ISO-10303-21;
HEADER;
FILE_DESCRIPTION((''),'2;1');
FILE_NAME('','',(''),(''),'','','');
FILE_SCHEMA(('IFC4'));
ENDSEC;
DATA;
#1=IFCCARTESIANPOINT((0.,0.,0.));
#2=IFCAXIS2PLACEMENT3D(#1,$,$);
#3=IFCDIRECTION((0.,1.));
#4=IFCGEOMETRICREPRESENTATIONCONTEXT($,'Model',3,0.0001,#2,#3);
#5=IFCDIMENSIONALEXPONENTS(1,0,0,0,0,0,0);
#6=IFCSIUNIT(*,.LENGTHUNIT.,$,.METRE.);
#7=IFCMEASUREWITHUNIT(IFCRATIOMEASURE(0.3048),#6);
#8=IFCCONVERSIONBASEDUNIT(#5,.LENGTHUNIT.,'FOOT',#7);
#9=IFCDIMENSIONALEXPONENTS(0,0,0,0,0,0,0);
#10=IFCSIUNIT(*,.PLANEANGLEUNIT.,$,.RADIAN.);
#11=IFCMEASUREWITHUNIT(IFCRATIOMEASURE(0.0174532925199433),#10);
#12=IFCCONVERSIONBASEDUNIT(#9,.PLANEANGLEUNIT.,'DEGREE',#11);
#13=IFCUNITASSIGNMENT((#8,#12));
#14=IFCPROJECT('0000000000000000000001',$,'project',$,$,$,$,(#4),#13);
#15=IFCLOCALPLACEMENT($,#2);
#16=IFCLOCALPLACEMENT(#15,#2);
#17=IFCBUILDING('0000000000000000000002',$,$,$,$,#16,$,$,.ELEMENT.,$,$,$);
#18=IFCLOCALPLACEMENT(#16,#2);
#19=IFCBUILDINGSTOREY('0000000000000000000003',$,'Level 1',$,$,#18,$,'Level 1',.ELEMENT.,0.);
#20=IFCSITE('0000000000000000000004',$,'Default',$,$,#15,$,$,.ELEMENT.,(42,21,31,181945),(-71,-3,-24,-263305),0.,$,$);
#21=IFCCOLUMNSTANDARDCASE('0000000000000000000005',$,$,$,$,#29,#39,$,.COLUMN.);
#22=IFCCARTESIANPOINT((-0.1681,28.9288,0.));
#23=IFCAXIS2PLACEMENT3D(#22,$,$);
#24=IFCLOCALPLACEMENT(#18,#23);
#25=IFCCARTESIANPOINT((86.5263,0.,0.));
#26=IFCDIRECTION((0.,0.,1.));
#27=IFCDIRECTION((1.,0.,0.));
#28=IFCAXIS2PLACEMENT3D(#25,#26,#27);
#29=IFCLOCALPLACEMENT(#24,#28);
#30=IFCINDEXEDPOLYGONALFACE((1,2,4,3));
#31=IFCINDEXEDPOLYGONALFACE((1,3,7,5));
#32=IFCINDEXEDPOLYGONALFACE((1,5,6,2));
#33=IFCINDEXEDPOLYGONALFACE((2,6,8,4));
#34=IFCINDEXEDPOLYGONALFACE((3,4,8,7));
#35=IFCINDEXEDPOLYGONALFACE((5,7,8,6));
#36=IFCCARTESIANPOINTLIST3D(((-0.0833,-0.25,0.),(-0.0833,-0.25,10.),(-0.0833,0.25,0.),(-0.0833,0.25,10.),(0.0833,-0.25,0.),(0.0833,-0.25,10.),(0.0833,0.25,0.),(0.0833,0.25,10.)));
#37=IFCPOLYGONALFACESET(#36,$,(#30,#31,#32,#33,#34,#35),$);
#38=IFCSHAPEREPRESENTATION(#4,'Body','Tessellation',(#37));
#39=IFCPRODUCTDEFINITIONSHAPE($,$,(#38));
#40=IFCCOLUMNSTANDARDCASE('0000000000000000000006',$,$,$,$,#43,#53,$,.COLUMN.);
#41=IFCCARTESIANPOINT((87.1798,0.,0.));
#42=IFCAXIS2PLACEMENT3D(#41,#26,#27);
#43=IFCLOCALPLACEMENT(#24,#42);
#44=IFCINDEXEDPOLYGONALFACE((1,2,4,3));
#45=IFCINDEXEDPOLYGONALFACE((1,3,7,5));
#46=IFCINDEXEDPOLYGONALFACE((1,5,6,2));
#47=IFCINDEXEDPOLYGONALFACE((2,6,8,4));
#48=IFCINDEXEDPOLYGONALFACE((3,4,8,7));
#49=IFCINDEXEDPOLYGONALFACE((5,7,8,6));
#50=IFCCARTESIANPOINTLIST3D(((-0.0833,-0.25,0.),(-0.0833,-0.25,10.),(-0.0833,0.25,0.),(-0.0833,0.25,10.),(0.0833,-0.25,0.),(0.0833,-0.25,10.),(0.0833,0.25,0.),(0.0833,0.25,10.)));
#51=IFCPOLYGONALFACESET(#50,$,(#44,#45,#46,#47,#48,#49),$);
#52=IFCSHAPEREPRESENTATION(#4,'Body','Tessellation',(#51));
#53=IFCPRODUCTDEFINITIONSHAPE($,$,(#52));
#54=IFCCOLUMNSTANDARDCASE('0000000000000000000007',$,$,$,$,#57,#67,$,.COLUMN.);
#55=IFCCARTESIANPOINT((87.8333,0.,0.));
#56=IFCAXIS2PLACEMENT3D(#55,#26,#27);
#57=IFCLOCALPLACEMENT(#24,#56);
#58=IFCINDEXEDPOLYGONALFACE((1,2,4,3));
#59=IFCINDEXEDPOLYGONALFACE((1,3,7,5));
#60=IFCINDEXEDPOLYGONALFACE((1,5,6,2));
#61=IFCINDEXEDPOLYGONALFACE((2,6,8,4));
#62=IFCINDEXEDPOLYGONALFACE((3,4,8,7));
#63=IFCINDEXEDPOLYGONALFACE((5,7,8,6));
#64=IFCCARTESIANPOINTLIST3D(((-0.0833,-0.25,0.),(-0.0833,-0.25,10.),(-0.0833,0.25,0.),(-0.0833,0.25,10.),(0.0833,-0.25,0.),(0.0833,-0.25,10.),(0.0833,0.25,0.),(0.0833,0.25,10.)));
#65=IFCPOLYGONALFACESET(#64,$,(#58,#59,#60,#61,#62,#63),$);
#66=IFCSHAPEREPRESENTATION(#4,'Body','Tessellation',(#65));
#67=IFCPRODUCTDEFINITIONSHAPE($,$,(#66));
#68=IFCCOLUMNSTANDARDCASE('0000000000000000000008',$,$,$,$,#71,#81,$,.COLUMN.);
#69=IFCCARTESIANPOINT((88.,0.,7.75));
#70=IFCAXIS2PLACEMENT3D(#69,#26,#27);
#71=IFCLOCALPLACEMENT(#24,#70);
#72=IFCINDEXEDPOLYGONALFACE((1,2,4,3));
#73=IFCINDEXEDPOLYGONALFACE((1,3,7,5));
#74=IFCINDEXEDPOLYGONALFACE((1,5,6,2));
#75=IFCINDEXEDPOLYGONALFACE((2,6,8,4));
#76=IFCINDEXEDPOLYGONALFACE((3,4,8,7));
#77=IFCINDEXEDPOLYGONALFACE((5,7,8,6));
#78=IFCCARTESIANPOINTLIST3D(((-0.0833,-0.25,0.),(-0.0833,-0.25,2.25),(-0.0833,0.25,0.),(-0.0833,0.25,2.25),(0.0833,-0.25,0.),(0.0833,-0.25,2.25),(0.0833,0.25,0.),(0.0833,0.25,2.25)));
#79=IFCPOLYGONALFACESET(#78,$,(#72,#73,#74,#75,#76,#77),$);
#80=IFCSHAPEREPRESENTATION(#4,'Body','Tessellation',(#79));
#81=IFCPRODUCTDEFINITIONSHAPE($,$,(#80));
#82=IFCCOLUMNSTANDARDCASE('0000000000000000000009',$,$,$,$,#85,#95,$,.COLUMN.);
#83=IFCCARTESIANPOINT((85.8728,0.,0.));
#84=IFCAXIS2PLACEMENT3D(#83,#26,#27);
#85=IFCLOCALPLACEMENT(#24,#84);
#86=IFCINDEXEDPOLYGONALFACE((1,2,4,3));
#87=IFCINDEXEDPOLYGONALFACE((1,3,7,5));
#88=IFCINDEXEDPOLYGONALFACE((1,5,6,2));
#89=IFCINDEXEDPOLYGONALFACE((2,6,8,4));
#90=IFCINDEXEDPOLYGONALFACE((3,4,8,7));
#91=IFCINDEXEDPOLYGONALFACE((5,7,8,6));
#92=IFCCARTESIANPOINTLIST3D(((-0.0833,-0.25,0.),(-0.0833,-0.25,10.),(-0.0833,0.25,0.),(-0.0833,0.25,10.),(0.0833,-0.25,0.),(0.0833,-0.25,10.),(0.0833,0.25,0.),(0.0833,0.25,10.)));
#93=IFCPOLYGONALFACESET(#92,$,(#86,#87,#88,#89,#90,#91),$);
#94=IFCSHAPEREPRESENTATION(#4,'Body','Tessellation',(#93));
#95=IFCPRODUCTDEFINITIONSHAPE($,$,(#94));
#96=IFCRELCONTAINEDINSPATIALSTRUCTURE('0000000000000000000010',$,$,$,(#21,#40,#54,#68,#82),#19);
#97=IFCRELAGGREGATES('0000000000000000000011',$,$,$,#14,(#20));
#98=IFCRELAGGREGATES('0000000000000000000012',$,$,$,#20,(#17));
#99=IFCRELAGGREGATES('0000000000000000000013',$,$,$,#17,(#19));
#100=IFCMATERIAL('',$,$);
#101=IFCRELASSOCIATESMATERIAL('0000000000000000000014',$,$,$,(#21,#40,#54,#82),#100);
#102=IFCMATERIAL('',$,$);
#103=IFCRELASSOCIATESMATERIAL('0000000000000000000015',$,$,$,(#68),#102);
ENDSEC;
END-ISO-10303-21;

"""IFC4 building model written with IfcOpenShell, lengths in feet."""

from ifc_helpers import new_model, entity, si_unit, converted_unit, direction, frame, origin, place, context, project, spatial, rectangle, extrude, material, element, save


model = new_model("IFC4")

# Units and contexts
model_context = context("Model", 3, precision=0.0001, world=origin(), true_north=direction((0.0, 1.0)))
ifc_project = project(units=[converted_unit("LENGTHUNIT", "FOOT", entity("IfcRatioMeasure", 0.3048), si_unit("LENGTHUNIT", "METRE"), dimensions=[1, 0, 0, 0, 0, 0, 0]), converted_unit("PLANEANGLEUNIT", "DEGREE", entity("IfcRatioMeasure", 0.0174532925199433), si_unit("PLANEANGLEUNIT", "RADIAN"), dimensions=[0, 0, 0, 0, 0, 0, 0])], contexts=[model_context])

# Site, building, storey
site_placement = place(None, origin())
site = spatial("IfcSite", under=ifc_project, at=site_placement, Name="Default", CompositionType="ELEMENT", RefLatitude=(42, 21, 31, 181945), RefLongitude=(-71, -3, -24, -263305), RefElevation=0.0)
building_placement = place(site_placement, origin())
building = spatial("IfcBuilding", under=site, at=building_placement, CompositionType="ELEMENT")
storey_placement = place(building_placement, origin())
storey = spatial("IfcBuildingStorey", under=building, at=storey_placement, Name="Level 1", LongName="Level 1", CompositionType="ELEMENT", Elevation=0.0)

# Columns
ifc_material_1 = material(Name="")
placement = place(storey_placement, frame((-0.1681, 28.9288, 0.0)))
for number, where, z_axis, x_axis in (
    (1, (86.5263, 0.0, 0.0), (0.0, 0.0, 1.0), (1.0, 0.0, 0.0)),
    (2, (87.1798, 0.0, 0.0), (0.0, 0.0, 1.0), (1.0, 0.0, 0.0)),
    (3, (87.8333, 0.0, 0.0), (0.0, 0.0, 1.0), (1.0, 0.0, 0.0)),
):
    element("IfcColumnStandardCase", number, at=place(placement, frame(where, z_axis=z_axis, x_axis=x_axis)), inside=storey, material=ifc_material_1, PredefinedType="COLUMN", context=model_context, shape_type="SweptSolid", body=[
        extrude(rectangle(XDim=0.1667, YDim=0.5), origin(), (0.0, 0.0, 1.0), 10.0),
    ])
ifc_material_2 = material(Name="")
for number, where, z_axis, x_axis in (
    (4, (88.0, 0.0, 7.75), (0.0, 0.0, 1.0), (1.0, 0.0, 0.0)),
):
    element("IfcColumnStandardCase", number, at=place(placement, frame(where, z_axis=z_axis, x_axis=x_axis)), inside=storey, material=ifc_material_2, PredefinedType="COLUMN", context=model_context, shape_type="SweptSolid", body=[
        extrude(rectangle(XDim=0.1667, YDim=0.5), origin(), (0.0, 0.0, 1.0), 2.25),
    ])
for number, where, z_axis, x_axis in (
    (5, (85.8728, 0.0, 0.0), (0.0, 0.0, 1.0), (1.0, 0.0, 0.0)),
):
    element("IfcColumnStandardCase", number, at=place(placement, frame(where, z_axis=z_axis, x_axis=x_axis)), inside=storey, material=ifc_material_1, PredefinedType="COLUMN", context=model_context, shape_type="SweptSolid", body=[
        extrude(rectangle(XDim=0.1667, YDim=0.5), origin(), (0.0, 0.0, 1.0), 10.0),
    ])

save(model, "model.ifc")
